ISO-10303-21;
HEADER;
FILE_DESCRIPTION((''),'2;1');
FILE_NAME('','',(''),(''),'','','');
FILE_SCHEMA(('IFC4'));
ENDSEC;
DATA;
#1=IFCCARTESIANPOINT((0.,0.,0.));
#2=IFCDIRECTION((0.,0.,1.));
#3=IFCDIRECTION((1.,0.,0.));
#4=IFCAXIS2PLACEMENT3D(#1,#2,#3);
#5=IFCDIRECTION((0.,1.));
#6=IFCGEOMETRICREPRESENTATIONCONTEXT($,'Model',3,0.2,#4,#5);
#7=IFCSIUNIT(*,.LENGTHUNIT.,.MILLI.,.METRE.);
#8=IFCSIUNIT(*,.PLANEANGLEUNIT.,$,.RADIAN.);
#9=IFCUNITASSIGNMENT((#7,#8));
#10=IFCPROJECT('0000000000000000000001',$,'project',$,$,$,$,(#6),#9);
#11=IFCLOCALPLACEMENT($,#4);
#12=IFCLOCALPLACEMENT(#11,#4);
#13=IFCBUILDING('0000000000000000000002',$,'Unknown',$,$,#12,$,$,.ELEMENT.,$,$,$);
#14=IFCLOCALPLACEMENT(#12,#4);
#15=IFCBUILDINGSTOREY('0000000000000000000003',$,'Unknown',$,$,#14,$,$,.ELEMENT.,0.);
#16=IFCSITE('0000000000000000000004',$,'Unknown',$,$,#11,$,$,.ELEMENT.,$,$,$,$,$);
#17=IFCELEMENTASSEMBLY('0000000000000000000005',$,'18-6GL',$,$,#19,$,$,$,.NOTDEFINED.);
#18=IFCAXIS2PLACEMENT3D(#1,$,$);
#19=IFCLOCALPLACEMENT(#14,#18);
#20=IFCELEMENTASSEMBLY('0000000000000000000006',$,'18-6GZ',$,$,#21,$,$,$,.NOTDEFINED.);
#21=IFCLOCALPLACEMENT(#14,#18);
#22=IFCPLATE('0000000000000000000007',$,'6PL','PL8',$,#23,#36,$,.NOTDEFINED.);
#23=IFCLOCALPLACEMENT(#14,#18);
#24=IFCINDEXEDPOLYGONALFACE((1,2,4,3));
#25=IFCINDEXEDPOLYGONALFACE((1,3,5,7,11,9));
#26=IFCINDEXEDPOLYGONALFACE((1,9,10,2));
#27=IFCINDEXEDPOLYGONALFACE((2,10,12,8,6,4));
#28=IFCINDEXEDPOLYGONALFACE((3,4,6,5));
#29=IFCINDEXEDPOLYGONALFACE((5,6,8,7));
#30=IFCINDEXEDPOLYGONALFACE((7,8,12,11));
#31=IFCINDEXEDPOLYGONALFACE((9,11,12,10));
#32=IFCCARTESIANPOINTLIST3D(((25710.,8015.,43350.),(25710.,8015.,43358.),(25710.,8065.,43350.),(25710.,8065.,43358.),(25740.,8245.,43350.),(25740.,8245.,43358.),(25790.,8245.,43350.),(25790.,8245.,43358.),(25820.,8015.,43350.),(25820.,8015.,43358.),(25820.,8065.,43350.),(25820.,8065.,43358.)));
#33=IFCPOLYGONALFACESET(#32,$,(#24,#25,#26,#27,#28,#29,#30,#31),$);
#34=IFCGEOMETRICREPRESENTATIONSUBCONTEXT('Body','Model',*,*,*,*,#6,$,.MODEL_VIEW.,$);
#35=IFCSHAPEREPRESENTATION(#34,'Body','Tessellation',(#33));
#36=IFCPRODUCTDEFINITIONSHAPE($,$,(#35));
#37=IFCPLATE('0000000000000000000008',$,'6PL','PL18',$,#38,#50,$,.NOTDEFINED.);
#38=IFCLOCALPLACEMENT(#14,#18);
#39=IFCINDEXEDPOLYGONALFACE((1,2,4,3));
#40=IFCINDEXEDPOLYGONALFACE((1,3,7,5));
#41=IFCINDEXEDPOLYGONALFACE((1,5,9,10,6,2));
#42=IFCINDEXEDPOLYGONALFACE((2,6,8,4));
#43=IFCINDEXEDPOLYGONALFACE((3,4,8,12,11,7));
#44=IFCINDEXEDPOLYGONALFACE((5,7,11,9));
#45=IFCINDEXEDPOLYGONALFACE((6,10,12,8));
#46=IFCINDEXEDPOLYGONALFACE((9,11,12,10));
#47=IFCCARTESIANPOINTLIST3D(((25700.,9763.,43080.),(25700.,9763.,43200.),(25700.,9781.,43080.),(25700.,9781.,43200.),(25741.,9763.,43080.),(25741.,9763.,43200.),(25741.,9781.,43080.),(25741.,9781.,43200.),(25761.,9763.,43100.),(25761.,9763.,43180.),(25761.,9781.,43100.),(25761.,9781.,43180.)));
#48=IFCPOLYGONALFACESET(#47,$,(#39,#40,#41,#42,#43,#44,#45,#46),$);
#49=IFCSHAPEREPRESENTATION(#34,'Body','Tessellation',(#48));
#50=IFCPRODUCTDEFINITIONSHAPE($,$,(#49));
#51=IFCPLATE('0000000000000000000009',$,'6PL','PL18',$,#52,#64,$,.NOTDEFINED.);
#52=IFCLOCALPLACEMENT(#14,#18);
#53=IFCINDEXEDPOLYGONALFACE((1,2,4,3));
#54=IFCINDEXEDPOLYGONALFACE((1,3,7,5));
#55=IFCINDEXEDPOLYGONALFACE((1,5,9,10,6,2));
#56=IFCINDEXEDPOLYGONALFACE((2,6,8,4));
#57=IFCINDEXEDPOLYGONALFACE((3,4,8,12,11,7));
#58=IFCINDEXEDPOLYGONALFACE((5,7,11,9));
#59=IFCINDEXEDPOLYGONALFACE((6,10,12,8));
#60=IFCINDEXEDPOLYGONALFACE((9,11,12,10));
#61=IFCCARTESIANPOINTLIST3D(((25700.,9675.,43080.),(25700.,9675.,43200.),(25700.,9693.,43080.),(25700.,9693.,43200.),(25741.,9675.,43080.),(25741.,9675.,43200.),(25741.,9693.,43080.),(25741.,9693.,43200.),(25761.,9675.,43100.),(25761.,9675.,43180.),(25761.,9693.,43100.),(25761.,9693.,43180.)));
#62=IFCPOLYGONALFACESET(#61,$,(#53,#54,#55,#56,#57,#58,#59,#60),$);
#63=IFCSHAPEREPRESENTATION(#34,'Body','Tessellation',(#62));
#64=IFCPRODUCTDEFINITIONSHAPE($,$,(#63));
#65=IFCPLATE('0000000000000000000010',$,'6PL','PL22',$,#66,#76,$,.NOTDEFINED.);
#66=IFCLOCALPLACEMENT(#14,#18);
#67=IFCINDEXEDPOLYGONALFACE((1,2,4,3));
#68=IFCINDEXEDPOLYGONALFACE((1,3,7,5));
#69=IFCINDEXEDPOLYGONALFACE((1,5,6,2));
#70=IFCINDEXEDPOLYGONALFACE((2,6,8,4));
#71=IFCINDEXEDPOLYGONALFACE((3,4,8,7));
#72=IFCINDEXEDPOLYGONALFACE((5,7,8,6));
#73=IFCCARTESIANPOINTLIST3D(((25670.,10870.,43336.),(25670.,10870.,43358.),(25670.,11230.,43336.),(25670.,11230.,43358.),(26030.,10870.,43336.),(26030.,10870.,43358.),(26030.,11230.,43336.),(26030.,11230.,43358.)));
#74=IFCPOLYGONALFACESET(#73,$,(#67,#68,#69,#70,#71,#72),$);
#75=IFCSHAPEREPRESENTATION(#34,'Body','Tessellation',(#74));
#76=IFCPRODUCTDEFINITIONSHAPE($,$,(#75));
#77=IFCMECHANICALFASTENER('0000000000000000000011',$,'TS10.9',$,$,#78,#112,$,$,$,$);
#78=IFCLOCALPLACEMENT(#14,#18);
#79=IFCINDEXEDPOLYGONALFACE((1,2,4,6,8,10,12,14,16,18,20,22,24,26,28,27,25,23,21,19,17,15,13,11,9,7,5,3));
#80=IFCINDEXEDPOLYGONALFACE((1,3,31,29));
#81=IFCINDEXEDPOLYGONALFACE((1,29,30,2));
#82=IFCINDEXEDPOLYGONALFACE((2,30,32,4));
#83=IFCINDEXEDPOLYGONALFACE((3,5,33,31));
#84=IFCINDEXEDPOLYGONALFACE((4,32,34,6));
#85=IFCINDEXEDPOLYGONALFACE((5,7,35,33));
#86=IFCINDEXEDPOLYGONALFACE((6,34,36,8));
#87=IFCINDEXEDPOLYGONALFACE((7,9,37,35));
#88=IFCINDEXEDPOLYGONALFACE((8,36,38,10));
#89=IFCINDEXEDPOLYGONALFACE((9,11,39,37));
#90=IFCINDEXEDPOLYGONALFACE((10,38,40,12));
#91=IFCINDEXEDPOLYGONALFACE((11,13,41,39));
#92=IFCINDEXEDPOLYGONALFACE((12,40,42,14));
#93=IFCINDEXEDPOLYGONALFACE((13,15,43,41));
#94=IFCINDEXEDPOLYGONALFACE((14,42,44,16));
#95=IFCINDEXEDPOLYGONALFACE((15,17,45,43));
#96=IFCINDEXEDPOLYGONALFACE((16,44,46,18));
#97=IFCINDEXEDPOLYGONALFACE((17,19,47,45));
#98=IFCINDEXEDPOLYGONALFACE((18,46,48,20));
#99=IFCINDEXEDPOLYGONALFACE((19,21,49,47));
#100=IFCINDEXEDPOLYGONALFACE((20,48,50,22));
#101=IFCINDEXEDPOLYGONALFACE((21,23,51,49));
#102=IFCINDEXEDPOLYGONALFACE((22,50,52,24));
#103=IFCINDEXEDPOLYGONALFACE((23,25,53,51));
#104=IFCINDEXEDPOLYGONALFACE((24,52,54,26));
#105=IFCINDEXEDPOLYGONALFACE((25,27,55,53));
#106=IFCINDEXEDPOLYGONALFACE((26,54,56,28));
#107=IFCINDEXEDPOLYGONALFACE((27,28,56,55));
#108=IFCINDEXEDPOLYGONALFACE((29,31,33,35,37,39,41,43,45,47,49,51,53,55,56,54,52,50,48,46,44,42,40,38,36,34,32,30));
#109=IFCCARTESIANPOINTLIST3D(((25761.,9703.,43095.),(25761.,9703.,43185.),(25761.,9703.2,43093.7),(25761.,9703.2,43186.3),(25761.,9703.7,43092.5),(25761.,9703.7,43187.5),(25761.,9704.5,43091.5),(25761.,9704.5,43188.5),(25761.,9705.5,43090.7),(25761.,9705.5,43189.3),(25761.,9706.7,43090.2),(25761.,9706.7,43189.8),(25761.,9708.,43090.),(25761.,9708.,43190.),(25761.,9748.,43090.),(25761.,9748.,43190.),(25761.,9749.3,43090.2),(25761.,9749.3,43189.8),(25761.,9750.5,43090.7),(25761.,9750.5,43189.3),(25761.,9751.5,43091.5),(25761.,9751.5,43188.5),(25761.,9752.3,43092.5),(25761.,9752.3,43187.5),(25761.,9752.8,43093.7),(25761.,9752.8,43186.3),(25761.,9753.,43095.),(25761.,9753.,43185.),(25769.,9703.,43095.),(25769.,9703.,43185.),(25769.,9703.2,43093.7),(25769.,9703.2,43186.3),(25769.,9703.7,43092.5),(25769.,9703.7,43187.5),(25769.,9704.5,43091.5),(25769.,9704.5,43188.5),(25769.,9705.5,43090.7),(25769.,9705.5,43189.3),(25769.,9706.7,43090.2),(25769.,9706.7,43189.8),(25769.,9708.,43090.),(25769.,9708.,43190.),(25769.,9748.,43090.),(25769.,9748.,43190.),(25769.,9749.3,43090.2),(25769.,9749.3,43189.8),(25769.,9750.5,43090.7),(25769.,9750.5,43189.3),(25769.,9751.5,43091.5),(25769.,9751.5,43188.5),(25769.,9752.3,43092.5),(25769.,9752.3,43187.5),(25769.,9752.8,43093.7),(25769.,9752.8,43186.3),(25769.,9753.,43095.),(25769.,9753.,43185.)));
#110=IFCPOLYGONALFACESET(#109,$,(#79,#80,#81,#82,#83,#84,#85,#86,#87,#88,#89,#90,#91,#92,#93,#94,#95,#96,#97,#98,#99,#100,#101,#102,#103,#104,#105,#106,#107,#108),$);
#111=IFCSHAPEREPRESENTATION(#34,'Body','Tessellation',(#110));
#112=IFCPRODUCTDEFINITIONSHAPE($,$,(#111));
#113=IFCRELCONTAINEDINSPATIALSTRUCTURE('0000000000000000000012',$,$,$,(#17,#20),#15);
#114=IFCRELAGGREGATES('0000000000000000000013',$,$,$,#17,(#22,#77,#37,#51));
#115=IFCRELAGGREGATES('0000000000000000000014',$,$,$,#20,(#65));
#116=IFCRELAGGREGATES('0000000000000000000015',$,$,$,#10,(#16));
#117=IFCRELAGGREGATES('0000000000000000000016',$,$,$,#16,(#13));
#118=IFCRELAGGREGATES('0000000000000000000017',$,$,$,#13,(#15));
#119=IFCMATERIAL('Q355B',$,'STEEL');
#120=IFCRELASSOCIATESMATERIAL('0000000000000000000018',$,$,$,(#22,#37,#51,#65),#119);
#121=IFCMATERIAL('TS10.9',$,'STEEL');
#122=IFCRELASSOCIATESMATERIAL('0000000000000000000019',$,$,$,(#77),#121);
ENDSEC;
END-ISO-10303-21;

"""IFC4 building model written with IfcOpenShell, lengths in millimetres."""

from ifc_helpers import new_model, si_unit, direction, frame, origin_with_axes, place, context, subcontext, project, spatial, line, arc, indexed_curve, outline, extrude, source, transform, mapped, material, element, aggregate, save


model = new_model("IFC4")

# Units and contexts
model_context = context("Model", 3, precision=0.2, world=origin_with_axes(), true_north=direction((0.0, 1.0)))
body_context = subcontext(model_context, "Body", "Model", "MODEL_VIEW")
ifc_project = project(units=[si_unit("LENGTHUNIT", "METRE", prefix="MILLI"), si_unit("PLANEANGLEUNIT", "RADIAN")], contexts=[model_context])

# Site, building, storey
site_placement = place(None, origin_with_axes())
site = spatial("IfcSite", under=ifc_project, at=site_placement, Name="Unknown", CompositionType="ELEMENT")
building_placement = place(site_placement, origin_with_axes())
building = spatial("IfcBuilding", under=site, at=building_placement, Name="Unknown", CompositionType="ELEMENT")
storey_placement = place(building_placement, origin_with_axes())
storey = spatial("IfcBuildingStorey", under=building, at=storey_placement, Name="Unknown", CompositionType="ELEMENT", Elevation=0.0)

# Element assembly
assembly_1_placement = place(storey_placement, frame((25765.0, 10900.0, 43140.0), z_axis=(-1.0, 0.0, 0.0), x_axis=(0.0, -1.0, 0.0)))
assembly_1 = element("IfcElementAssembly", 1, at=assembly_1_placement, inside=storey, Name="18-6GL", PredefinedType="NOTDEFINED")
ifc_material_1 = material(Name="Q355B", Category="STEEL")

# Element assembly
assembly_2_placement = place(storey_placement, frame((25850.0, 11050.0, 35950.0), z_axis=(-1.0, 0.0, 0.0), x_axis=(0.0, 0.0, 1.0)))
assembly_2 = element("IfcElementAssembly", 2, at=assembly_2_placement, inside=storey, Name="18-6GZ", PredefinedType="NOTDEFINED")

# Plates
plate_1_placement = place(assembly_1_placement, frame((2835.0, 214.0, -55.0), z_axis=(0.0, -1.0, 0.0), x_axis=(1.0, 0.0, 0.0)))
plate_1 = element("IfcPlate", 3, at=plate_1_placement, material=ifc_material_1, Name="6PL", Description="PL8", PredefinedType="NOTDEFINED", context=body_context, shape_type="SolidModel", body=[
    extrude(outline(indexed_curve([(0.0, 0.0), (50.0, 0.0), (50.0, 110.0), (0.0, 110.0), (-180.0, 80.0), (-180.0, 30.0)], segments=[line(1, 2, 3, 4, 5, 6, 1)])), frame((0.0, 0.0, 4.0), z_axis=(0.0, 0.0, 1.0), x_axis=(1.0, 0.0, 0.0)), (0.0, 0.0, -1.0), 8.0),
])
plate_2_placement = place(assembly_1_placement, frame((1128.0, -60.0, 65.0), z_axis=(1.0, 0.0, 0.0), x_axis=(0.0, 0.0, -1.0)))
plate_2 = element("IfcPlate", 4, at=plate_2_placement, material=ifc_material_1, Name="6PL", Description="PL18", PredefinedType="NOTDEFINED", context=body_context, shape_type="SolidModel", body=[
    extrude(outline(indexed_curve([(0.0, 0.0), (41.0, 0.0), (61.0, 20.0), (61.0, 100.0), (41.0, 120.0), (0.0, 120.0)], segments=[line(1, 2, 3, 4, 5, 6, 1)])), frame((0.0, 0.0, 9.0), z_axis=(0.0, 0.0, 1.0), x_axis=(1.0, 0.0, 0.0)), (0.0, 0.0, -1.0), 18.0),
])
plate_3_placement = place(assembly_1_placement, frame((1216.0, -60.0, 65.0), z_axis=(1.0, 0.0, 0.0), x_axis=(0.0, 0.0, -1.0)))
plate_3 = element("IfcPlate", 5, at=plate_3_placement, material=ifc_material_1, Name="6PL", Description="PL18", PredefinedType="NOTDEFINED", context=body_context, shape_type="SolidModel", body=[
    extrude(outline(indexed_curve([(0.0, 0.0), (41.0, 0.0), (61.0, 20.0), (61.0, 100.0), (41.0, 120.0), (0.0, 120.0)], segments=[line(1, 2, 3, 4, 5, 6, 1)])), frame((0.0, 0.0, 9.0), z_axis=(0.0, 0.0, 1.0), x_axis=(1.0, 0.0, 0.0)), (0.0, 0.0, -1.0), 18.0),
])
plate_4_placement = place(assembly_2_placement, frame((7397.0, -180.0, 180.0), z_axis=(1.0, 0.0, 0.0), x_axis=(0.0, 0.0, -1.0)))
plate_4 = element("IfcPlate", 6, at=plate_4_placement, material=ifc_material_1, Name="6PL", Description="PL22", PredefinedType="NOTDEFINED", context=body_context, shape_type="SolidModel", body=[
    extrude(outline(indexed_curve([(0.0, 0.0), (360.0, 0.0), (360.0, 360.0), (0.0, 360.0)], segments=[line(1, 2, 3, 4, 1)])), frame((0.0, 0.0, 11.0), z_axis=(0.0, 0.0, 1.0), x_axis=(1.0, 0.0, 0.0)), (0.0, 0.0, -1.0), 22.0),
])

# Mechanical fastener
ifc_material_2 = material(Name="TS10.9", Category="STEEL")
shared_shape_1 = source(origin_with_axes(), body_context, "Body", "SweptSolid", [
    extrude(outline(indexed_curve([(-45.0, 25.0), (45.0, 25.0), (45.0, 25.0), (48.5, 23.5), (50.0, 20.0), (50.0, -20.0), (48.5, -23.5), (45.0, -25.0), (-45.0, -25.0), (-45.5, -25.0), (-50.0, -20.0), (-50.0, 20.0), (-48.5, 23.5)], segments=[line(1, 2, 3), arc(3, 4, 5), line(5, 6), arc(6, 7, 8), line(8, 9), arc(9, 10, 11), line(11, 12), arc(12, 13, 1)])), frame((0.0, 0.0, 4.0), z_axis=(0.0, 0.0, -1.0), x_axis=(0.0, 1.0, 0.0)), (0.0, 0.0, 1.0), 8.0),
])
mechanical_fastener_1_placement = place(assembly_1_placement, frame((1172.0, 0.0, 0.0), z_axis=(0.0, 0.0, 1.0), x_axis=(-1.0, 0.0, 0.0)))
mechanical_fastener_1 = element("IfcMechanicalFastener", 7, at=mechanical_fastener_1_placement, material=ifc_material_2, Name="TS10.9", context=body_context, shape_type="MappedRepresentation", body=[
    mapped(shared_shape_1, transform((0.0, 0.0, 0.0))),
])
aggregate(assembly_1, [plate_1, mechanical_fastener_1, plate_2, plate_3])
aggregate(assembly_2, [plate_4])

save(model, "model.ifc")
